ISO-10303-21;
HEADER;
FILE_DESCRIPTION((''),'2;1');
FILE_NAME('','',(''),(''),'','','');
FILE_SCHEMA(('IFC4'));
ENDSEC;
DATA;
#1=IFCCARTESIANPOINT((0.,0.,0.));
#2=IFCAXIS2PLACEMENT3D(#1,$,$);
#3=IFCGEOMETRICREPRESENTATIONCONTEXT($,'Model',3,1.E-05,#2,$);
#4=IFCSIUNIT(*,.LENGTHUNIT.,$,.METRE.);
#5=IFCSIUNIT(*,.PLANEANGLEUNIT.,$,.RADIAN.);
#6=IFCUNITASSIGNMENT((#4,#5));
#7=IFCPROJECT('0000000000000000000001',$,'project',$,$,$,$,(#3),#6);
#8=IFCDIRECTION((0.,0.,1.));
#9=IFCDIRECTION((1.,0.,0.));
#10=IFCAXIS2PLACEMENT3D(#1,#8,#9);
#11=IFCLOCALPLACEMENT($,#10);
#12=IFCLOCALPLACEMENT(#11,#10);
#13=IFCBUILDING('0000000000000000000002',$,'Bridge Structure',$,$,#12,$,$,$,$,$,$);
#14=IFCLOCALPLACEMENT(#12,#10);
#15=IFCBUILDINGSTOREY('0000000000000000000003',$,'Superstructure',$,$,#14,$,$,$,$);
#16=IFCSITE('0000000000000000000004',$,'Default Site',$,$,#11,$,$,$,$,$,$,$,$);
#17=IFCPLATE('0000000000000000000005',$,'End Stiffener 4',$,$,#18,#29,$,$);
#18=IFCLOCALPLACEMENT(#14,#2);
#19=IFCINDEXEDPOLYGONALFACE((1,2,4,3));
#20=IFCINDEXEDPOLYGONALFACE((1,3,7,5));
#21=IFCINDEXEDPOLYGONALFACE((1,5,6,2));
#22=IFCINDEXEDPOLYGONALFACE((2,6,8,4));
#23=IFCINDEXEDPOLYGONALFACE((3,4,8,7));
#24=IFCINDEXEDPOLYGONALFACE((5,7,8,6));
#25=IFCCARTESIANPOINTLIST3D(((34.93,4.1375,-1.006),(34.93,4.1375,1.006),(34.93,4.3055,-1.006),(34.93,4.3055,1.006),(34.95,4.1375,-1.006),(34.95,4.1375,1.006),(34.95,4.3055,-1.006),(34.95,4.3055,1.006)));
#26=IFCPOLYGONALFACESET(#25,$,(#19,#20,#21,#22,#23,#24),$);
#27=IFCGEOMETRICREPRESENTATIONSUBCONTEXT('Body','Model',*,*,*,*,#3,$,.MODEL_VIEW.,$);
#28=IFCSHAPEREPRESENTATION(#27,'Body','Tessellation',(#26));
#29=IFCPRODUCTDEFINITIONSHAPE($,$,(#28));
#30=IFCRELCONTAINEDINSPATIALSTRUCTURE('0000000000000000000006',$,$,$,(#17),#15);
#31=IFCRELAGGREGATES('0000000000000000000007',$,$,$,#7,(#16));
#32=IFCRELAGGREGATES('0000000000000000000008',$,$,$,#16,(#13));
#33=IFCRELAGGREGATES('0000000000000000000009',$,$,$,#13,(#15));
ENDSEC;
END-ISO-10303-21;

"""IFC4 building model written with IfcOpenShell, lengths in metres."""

from ifc_helpers import new_model, si_unit, frame, origin, origin_with_axes, origin_2d_with_axis, place, context, subcontext, project, spatial, rectangle, extrude, element, save


model = new_model("IFC4")

# Units and contexts
model_context = context("Model", 3, precision=1e-05, world=origin())
body_context = subcontext(model_context, "Body", "Model", "MODEL_VIEW")
ifc_project = project(units=[si_unit("LENGTHUNIT", "METRE"), si_unit("PLANEANGLEUNIT", "RADIAN")], contexts=[model_context])

# Site, building, storey
site_placement = place(None, origin_with_axes())
site = spatial("IfcSite", under=ifc_project, at=site_placement, Name="Default Site")
building_placement = place(site_placement, origin_with_axes())
building = spatial("IfcBuilding", under=site, at=building_placement, Name="Bridge Structure")
storey_placement = place(building_placement, origin_with_axes())
storey = spatial("IfcBuildingStorey", under=building, at=storey_placement, Name="Superstructure")

# Plate
for number, where, z_axis, x_axis, name in (
    (1, (34.94, 4.2215, -1.006), (0.0, 0.0, 1.0), (1.0, 0.0, 0.0), "End Stiffener 4"),
):
    element("IfcPlate", number, at=place(storey_placement, frame(where, z_axis=z_axis, x_axis=x_axis)), inside=storey, Name=name, context=body_context, shape_type="SweptSolid", body=[
        extrude(rectangle(XDim=0.02, YDim=0.168, at=origin_2d_with_axis()), origin_with_axes(), (0.0, 0.0, 1.0), 2.012),
    ])

save(model, "model.ifc")
